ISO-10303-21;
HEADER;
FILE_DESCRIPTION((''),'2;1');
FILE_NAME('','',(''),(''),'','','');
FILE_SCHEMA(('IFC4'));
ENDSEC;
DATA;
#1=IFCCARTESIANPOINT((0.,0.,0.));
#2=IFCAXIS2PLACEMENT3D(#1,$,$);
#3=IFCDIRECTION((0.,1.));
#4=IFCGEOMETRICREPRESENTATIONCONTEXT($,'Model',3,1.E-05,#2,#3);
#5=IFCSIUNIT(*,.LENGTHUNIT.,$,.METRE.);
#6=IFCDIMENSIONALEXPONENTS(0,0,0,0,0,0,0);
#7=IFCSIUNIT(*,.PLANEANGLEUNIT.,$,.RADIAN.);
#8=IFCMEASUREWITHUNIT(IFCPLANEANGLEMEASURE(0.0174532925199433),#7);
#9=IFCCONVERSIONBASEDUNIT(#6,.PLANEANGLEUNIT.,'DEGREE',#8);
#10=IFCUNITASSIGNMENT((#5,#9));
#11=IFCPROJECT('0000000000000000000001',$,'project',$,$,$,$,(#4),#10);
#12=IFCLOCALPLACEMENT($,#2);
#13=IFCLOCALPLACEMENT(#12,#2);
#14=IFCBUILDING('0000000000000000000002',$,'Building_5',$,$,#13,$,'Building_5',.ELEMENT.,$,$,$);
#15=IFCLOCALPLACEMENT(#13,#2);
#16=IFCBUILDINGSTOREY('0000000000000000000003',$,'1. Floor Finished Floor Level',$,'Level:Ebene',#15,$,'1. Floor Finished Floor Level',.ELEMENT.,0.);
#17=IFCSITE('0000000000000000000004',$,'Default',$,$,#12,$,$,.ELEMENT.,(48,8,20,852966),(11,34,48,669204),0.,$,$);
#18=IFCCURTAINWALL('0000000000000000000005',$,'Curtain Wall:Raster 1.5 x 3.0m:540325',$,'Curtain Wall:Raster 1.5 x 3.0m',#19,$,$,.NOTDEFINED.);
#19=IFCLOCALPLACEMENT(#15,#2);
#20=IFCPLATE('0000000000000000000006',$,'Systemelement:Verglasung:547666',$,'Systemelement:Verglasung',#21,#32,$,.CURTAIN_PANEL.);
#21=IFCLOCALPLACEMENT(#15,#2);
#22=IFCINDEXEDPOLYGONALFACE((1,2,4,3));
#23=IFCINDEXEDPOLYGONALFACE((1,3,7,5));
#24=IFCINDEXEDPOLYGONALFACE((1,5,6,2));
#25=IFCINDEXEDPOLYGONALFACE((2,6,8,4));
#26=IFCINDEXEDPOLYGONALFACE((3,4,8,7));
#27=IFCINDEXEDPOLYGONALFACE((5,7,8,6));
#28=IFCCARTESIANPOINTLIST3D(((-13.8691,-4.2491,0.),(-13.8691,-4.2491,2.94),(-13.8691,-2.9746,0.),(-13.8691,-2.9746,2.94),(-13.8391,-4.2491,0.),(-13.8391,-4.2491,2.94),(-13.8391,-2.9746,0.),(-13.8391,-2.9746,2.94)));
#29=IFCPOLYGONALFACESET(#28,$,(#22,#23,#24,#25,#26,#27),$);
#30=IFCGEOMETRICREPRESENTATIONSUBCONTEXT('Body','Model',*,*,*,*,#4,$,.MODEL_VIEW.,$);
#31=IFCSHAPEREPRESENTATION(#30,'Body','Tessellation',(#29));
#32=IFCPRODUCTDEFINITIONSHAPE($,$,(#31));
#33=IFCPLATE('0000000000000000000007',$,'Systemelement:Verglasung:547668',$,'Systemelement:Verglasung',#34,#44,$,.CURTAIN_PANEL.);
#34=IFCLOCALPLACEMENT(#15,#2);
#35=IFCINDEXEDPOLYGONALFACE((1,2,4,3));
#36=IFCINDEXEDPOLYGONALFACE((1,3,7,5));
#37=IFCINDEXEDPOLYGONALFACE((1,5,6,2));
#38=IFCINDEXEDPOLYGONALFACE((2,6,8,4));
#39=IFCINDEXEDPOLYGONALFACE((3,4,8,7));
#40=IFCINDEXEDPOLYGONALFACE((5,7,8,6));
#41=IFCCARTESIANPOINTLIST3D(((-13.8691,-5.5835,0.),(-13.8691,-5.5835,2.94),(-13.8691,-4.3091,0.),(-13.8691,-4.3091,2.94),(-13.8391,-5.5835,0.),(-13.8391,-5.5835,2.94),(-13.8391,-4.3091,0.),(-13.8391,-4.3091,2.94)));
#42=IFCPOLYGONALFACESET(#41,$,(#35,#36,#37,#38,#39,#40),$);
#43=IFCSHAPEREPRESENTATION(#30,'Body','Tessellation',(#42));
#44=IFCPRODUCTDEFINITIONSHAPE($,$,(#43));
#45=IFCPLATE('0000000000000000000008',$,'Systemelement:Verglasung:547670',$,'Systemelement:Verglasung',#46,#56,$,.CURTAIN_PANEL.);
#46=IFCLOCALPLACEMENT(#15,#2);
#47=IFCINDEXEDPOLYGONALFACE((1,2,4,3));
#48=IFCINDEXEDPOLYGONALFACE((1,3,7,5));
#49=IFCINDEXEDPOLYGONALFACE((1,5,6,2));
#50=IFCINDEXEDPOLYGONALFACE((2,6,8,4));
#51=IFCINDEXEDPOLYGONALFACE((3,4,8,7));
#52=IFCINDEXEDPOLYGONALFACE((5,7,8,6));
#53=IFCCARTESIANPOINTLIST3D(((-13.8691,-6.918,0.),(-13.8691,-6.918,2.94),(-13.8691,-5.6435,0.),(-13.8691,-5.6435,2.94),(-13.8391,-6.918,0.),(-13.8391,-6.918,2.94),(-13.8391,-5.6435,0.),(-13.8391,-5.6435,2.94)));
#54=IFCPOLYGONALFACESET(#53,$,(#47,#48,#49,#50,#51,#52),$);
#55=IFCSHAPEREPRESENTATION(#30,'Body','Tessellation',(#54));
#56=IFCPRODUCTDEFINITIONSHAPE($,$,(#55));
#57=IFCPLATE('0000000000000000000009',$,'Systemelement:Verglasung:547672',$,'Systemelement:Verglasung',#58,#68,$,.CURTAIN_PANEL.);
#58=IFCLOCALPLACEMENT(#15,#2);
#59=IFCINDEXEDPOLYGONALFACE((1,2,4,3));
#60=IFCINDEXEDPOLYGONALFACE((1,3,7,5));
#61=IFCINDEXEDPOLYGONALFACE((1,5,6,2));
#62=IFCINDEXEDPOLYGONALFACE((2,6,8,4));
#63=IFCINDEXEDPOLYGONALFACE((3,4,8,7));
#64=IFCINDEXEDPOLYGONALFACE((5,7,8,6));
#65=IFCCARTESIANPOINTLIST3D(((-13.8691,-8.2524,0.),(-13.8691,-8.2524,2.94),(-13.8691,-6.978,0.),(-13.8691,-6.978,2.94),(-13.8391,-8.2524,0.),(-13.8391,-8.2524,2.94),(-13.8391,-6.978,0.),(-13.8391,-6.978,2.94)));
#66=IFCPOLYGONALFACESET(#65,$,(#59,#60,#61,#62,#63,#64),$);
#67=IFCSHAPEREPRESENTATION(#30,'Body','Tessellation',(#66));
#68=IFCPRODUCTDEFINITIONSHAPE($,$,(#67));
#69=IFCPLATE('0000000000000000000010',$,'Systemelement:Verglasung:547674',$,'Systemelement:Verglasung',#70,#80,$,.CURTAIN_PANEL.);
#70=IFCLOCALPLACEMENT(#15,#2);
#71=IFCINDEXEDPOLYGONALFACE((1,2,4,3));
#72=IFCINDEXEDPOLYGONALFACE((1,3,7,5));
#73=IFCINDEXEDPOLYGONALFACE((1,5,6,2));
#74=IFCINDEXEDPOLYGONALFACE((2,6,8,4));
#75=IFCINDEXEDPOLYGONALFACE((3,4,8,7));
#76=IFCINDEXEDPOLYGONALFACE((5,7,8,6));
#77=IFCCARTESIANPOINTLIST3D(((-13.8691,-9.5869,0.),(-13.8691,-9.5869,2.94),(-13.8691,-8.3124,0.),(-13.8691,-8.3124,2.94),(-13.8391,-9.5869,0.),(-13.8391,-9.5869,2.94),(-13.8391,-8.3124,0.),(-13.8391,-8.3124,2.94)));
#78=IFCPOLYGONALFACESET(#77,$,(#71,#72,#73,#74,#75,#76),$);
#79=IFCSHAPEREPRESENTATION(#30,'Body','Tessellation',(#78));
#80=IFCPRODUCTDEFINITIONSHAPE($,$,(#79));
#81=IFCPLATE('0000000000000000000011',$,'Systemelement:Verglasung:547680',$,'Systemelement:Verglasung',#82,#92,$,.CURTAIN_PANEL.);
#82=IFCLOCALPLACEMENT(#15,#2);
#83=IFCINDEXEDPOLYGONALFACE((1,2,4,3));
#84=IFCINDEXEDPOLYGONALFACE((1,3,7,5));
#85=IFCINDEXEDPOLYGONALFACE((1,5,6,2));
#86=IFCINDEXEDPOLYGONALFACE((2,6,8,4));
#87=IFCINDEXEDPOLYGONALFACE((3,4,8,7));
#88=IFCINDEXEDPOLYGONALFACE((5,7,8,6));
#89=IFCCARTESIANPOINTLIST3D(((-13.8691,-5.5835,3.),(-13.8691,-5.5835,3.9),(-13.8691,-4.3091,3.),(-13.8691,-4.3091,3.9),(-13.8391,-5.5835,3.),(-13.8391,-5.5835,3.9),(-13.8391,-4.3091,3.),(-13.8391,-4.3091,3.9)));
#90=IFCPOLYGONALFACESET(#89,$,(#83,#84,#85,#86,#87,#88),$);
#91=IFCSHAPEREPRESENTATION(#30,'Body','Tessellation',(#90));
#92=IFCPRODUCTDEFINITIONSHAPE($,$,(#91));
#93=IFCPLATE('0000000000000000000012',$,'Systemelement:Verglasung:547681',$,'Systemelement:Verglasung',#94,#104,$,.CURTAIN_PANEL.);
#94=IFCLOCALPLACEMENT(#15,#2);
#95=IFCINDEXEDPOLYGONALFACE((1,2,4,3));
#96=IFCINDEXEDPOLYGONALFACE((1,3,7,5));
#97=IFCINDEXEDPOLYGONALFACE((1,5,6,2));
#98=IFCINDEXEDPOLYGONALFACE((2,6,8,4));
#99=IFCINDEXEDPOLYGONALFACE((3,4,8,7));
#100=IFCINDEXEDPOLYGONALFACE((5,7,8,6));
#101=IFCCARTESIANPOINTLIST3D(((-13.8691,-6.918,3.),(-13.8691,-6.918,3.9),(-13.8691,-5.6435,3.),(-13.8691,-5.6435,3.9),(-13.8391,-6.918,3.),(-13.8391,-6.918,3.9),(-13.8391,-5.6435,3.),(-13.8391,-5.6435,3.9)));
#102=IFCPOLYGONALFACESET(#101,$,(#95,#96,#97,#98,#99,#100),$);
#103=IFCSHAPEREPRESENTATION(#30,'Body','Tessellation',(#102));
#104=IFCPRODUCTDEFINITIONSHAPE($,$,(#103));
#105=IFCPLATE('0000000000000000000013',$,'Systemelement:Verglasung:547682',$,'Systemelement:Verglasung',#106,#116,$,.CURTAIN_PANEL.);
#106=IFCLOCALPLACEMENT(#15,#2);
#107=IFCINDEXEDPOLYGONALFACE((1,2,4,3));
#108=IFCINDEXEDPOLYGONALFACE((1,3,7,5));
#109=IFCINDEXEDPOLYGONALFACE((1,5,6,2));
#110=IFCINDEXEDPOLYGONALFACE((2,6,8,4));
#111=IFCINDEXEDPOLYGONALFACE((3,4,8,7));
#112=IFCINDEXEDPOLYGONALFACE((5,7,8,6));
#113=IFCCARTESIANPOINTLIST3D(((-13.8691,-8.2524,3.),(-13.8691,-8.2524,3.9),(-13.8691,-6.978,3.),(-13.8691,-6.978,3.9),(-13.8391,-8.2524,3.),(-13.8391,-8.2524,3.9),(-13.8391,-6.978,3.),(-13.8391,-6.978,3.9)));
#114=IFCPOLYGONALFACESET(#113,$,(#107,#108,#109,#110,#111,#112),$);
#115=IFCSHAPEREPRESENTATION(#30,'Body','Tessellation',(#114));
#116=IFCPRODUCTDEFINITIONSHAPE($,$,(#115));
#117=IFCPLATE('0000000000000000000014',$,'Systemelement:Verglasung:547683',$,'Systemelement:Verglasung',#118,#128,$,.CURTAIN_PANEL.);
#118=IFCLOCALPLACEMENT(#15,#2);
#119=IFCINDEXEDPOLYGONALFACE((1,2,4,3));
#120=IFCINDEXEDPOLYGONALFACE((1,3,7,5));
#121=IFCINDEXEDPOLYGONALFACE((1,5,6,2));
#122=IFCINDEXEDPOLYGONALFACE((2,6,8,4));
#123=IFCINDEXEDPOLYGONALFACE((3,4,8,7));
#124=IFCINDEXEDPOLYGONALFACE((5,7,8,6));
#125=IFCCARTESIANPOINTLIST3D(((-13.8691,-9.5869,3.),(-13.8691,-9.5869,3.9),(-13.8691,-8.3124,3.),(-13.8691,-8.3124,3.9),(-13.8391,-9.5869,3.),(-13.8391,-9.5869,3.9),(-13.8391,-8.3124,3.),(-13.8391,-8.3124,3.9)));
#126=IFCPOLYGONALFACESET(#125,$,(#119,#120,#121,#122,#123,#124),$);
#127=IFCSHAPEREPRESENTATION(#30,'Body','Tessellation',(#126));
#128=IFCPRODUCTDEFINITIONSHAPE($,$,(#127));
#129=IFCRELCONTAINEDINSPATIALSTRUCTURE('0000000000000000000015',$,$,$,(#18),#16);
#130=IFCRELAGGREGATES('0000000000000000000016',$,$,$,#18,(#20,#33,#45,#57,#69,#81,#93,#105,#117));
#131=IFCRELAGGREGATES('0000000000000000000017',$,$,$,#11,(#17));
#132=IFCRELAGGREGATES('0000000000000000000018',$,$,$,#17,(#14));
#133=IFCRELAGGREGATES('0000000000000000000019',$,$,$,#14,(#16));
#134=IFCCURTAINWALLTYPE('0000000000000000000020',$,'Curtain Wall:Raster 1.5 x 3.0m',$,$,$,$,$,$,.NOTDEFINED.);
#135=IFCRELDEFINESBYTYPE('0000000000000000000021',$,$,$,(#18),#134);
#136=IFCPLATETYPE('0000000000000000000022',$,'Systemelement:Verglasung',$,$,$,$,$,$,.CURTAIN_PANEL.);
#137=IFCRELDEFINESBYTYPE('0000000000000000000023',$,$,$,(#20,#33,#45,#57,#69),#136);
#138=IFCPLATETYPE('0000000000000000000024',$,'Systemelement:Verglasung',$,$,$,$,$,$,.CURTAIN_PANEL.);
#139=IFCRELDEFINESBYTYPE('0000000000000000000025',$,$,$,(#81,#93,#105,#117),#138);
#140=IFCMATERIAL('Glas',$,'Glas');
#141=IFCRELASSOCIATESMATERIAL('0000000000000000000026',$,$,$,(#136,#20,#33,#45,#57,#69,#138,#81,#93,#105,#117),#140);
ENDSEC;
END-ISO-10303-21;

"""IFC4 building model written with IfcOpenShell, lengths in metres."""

from ifc_helpers import new_model, entity, si_unit, converted_unit, direction, frame, origin, place, context, subcontext, project, spatial, indexed_curve, outline, extrude, source, transform, mapped, material, type_object, type_shapes, element, aggregate, save


model = new_model("IFC4")

# Units and contexts
model_context = context("Model", 3, precision=1e-05, world=origin(), true_north=direction((0.0, 1.0)))
body_context = subcontext(model_context, "Body", "Model", "MODEL_VIEW")
ifc_project = project(units=[si_unit("LENGTHUNIT", "METRE"), converted_unit("PLANEANGLEUNIT", "DEGREE", entity("IfcPlaneAngleMeasure", 0.0174532925199433), si_unit("PLANEANGLEUNIT", "RADIAN"), dimensions=[0, 0, 0, 0, 0, 0, 0])], contexts=[model_context])

# Site, building, storey
site_placement = place(None, origin())
site = spatial("IfcSite", under=ifc_project, at=site_placement, Name="Default", CompositionType="ELEMENT", RefLatitude=(48, 8, 20, 852966), RefLongitude=(11, 34, 48, 669204), RefElevation=0.0)
building_placement = place(site_placement, origin())
building = spatial("IfcBuilding", under=site, at=building_placement, Name="Building_5", LongName="Building_5", CompositionType="ELEMENT")
storey_placement = place(building_placement, origin())
storey = spatial("IfcBuildingStorey", under=building, at=storey_placement, Name="1. Floor Finished Floor Level", ObjectType="Level:Ebene", LongName="1. Floor Finished Floor Level", CompositionType="ELEMENT", Elevation=0.0)

# Curtain wall, plates
curtain_wall_type = type_object("IfcCurtainWallType", Name="Curtain Wall:Raster 1.5 x 3.0m", PredefinedType="NOTDEFINED")
curtain_wall_placement = place(storey_placement, origin())
curtain_wall = element("IfcCurtainWall", 1, at=curtain_wall_placement, inside=storey, type_object=curtain_wall_type, Name="Curtain Wall:Raster 1.5 x 3.0m:540325", ObjectType="Curtain Wall:Raster 1.5 x 3.0m", PredefinedType="NOTDEFINED")
ifc_material_1 = material(Name="Glas", Category="Glas")
plate_type_1 = type_object("IfcPlateType", Name="Systemelement:Verglasung", PredefinedType="CURTAIN_PANEL", material=ifc_material_1)
shared_shape_1 = source(origin(), body_context, "Body", "SweptSolid", [
    extrude(outline(indexed_curve([(-0.015, -0.6372), (0.015, -0.6372), (0.015, 0.6372), (-0.015, 0.6372), (-0.015, -0.6372)], self_intersect=False)), frame((0.0, 0.0, 0.0), z_axis=(0.0, 0.0, 1.0), x_axis=(0.0, 1.0, 0.0)), (0.0, 0.0, 1.0), 2.94),
])
type_shapes(plate_type_1, [shared_shape_1])
plate_1_placement = place(curtain_wall_placement, frame((-13.8541, -3.6119, 0.0), z_axis=(0.0, 0.0, 1.0), x_axis=(0.0, -1.0, 0.0)))
plate_1 = element("IfcPlate", 2, at=plate_1_placement, type_object=plate_type_1, material=ifc_material_1, Name="Systemelement:Verglasung:547666", ObjectType="Systemelement:Verglasung", PredefinedType="CURTAIN_PANEL", context=body_context, shape_type="MappedRepresentation", body=[
    mapped(shared_shape_1, transform((0.0, 0.0, 0.0), scale=1.0)),
])
plate_2_placement = place(curtain_wall_placement, frame((-13.8541, -4.9463, 0.0), z_axis=(0.0, 0.0, 1.0), x_axis=(0.0, -1.0, 0.0)))
plate_2 = element("IfcPlate", 3, at=plate_2_placement, type_object=plate_type_1, material=ifc_material_1, Name="Systemelement:Verglasung:547668", ObjectType="Systemelement:Verglasung", PredefinedType="CURTAIN_PANEL", context=body_context, shape_type="MappedRepresentation", body=[
    mapped(shared_shape_1, transform((0.0, 0.0, 0.0), scale=1.0)),
])
plate_3_placement = place(curtain_wall_placement, frame((-13.8541, -6.2807, 0.0), z_axis=(0.0, 0.0, 1.0), x_axis=(0.0, -1.0, 0.0)))
plate_3 = element("IfcPlate", 4, at=plate_3_placement, type_object=plate_type_1, material=ifc_material_1, Name="Systemelement:Verglasung:547670", ObjectType="Systemelement:Verglasung", PredefinedType="CURTAIN_PANEL", context=body_context, shape_type="MappedRepresentation", body=[
    mapped(shared_shape_1, transform((0.0, 0.0, 0.0), scale=1.0)),
])
plate_4_placement = place(curtain_wall_placement, frame((-13.8541, -7.6152, 0.0), z_axis=(0.0, 0.0, 1.0), x_axis=(0.0, -1.0, 0.0)))
plate_4 = element("IfcPlate", 5, at=plate_4_placement, type_object=plate_type_1, material=ifc_material_1, Name="Systemelement:Verglasung:547672", ObjectType="Systemelement:Verglasung", PredefinedType="CURTAIN_PANEL", context=body_context, shape_type="MappedRepresentation", body=[
    mapped(shared_shape_1, transform((0.0, 0.0, 0.0), scale=1.0)),
])
plate_5_placement = place(curtain_wall_placement, frame((-13.8541, -8.9496, 0.0), z_axis=(0.0, 0.0, 1.0), x_axis=(0.0, -1.0, 0.0)))
plate_5 = element("IfcPlate", 6, at=plate_5_placement, type_object=plate_type_1, material=ifc_material_1, Name="Systemelement:Verglasung:547674", ObjectType="Systemelement:Verglasung", PredefinedType="CURTAIN_PANEL", context=body_context, shape_type="MappedRepresentation", body=[
    mapped(shared_shape_1, transform((0.0, 0.0, 0.0), scale=1.0)),
])
plate_type_2 = type_object("IfcPlateType", Name="Systemelement:Verglasung", PredefinedType="CURTAIN_PANEL", material=ifc_material_1)
shared_shape_2 = source(origin(), body_context, "Body", "SweptSolid", [
    extrude(outline(indexed_curve([(-0.015, -0.6372), (0.015, -0.6372), (0.015, 0.6372), (-0.015, 0.6372), (-0.015, -0.6372)], self_intersect=False)), frame((0.0, 0.0, 0.0), z_axis=(0.0, 0.0, 1.0), x_axis=(0.0, 1.0, 0.0)), (0.0, 0.0, 1.0), 0.9),
])
type_shapes(plate_type_2, [shared_shape_2])
plate_6_placement = place(curtain_wall_placement, frame((-13.8541, -4.9463, 3.0), z_axis=(0.0, 0.0, 1.0), x_axis=(0.0, -1.0, 0.0)))
plate_6 = element("IfcPlate", 7, at=plate_6_placement, type_object=plate_type_2, material=ifc_material_1, Name="Systemelement:Verglasung:547680", ObjectType="Systemelement:Verglasung", PredefinedType="CURTAIN_PANEL", context=body_context, shape_type="MappedRepresentation", body=[
    mapped(shared_shape_2, transform((0.0, 0.0, 0.0), scale=1.0)),
])
plate_7_placement = place(curtain_wall_placement, frame((-13.8541, -6.2807, 3.0), z_axis=(0.0, 0.0, 1.0), x_axis=(0.0, -1.0, 0.0)))
plate_7 = element("IfcPlate", 8, at=plate_7_placement, type_object=plate_type_2, material=ifc_material_1, Name="Systemelement:Verglasung:547681", ObjectType="Systemelement:Verglasung", PredefinedType="CURTAIN_PANEL", context=body_context, shape_type="MappedRepresentation", body=[
    mapped(shared_shape_2, transform((0.0, 0.0, 0.0), scale=1.0)),
])
plate_8_placement = place(curtain_wall_placement, frame((-13.8541, -7.6152, 3.0), z_axis=(0.0, 0.0, 1.0), x_axis=(0.0, -1.0, 0.0)))
plate_8 = element("IfcPlate", 9, at=plate_8_placement, type_object=plate_type_2, material=ifc_material_1, Name="Systemelement:Verglasung:547682", ObjectType="Systemelement:Verglasung", PredefinedType="CURTAIN_PANEL", context=body_context, shape_type="MappedRepresentation", body=[
    mapped(shared_shape_2, transform((0.0, 0.0, 0.0), scale=1.0)),
])
plate_9_placement = place(curtain_wall_placement, frame((-13.8541, -8.9496, 3.0), z_axis=(0.0, 0.0, 1.0), x_axis=(0.0, -1.0, 0.0)))
plate_9 = element("IfcPlate", 10, at=plate_9_placement, type_object=plate_type_2, material=ifc_material_1, Name="Systemelement:Verglasung:547683", ObjectType="Systemelement:Verglasung", PredefinedType="CURTAIN_PANEL", context=body_context, shape_type="MappedRepresentation", body=[
    mapped(shared_shape_2, transform((0.0, 0.0, 0.0), scale=1.0)),
])
aggregate(curtain_wall, [plate_1, plate_2, plate_3, plate_4, plate_5, plate_6, plate_7, plate_8, plate_9])

save(model, "model.ifc")
